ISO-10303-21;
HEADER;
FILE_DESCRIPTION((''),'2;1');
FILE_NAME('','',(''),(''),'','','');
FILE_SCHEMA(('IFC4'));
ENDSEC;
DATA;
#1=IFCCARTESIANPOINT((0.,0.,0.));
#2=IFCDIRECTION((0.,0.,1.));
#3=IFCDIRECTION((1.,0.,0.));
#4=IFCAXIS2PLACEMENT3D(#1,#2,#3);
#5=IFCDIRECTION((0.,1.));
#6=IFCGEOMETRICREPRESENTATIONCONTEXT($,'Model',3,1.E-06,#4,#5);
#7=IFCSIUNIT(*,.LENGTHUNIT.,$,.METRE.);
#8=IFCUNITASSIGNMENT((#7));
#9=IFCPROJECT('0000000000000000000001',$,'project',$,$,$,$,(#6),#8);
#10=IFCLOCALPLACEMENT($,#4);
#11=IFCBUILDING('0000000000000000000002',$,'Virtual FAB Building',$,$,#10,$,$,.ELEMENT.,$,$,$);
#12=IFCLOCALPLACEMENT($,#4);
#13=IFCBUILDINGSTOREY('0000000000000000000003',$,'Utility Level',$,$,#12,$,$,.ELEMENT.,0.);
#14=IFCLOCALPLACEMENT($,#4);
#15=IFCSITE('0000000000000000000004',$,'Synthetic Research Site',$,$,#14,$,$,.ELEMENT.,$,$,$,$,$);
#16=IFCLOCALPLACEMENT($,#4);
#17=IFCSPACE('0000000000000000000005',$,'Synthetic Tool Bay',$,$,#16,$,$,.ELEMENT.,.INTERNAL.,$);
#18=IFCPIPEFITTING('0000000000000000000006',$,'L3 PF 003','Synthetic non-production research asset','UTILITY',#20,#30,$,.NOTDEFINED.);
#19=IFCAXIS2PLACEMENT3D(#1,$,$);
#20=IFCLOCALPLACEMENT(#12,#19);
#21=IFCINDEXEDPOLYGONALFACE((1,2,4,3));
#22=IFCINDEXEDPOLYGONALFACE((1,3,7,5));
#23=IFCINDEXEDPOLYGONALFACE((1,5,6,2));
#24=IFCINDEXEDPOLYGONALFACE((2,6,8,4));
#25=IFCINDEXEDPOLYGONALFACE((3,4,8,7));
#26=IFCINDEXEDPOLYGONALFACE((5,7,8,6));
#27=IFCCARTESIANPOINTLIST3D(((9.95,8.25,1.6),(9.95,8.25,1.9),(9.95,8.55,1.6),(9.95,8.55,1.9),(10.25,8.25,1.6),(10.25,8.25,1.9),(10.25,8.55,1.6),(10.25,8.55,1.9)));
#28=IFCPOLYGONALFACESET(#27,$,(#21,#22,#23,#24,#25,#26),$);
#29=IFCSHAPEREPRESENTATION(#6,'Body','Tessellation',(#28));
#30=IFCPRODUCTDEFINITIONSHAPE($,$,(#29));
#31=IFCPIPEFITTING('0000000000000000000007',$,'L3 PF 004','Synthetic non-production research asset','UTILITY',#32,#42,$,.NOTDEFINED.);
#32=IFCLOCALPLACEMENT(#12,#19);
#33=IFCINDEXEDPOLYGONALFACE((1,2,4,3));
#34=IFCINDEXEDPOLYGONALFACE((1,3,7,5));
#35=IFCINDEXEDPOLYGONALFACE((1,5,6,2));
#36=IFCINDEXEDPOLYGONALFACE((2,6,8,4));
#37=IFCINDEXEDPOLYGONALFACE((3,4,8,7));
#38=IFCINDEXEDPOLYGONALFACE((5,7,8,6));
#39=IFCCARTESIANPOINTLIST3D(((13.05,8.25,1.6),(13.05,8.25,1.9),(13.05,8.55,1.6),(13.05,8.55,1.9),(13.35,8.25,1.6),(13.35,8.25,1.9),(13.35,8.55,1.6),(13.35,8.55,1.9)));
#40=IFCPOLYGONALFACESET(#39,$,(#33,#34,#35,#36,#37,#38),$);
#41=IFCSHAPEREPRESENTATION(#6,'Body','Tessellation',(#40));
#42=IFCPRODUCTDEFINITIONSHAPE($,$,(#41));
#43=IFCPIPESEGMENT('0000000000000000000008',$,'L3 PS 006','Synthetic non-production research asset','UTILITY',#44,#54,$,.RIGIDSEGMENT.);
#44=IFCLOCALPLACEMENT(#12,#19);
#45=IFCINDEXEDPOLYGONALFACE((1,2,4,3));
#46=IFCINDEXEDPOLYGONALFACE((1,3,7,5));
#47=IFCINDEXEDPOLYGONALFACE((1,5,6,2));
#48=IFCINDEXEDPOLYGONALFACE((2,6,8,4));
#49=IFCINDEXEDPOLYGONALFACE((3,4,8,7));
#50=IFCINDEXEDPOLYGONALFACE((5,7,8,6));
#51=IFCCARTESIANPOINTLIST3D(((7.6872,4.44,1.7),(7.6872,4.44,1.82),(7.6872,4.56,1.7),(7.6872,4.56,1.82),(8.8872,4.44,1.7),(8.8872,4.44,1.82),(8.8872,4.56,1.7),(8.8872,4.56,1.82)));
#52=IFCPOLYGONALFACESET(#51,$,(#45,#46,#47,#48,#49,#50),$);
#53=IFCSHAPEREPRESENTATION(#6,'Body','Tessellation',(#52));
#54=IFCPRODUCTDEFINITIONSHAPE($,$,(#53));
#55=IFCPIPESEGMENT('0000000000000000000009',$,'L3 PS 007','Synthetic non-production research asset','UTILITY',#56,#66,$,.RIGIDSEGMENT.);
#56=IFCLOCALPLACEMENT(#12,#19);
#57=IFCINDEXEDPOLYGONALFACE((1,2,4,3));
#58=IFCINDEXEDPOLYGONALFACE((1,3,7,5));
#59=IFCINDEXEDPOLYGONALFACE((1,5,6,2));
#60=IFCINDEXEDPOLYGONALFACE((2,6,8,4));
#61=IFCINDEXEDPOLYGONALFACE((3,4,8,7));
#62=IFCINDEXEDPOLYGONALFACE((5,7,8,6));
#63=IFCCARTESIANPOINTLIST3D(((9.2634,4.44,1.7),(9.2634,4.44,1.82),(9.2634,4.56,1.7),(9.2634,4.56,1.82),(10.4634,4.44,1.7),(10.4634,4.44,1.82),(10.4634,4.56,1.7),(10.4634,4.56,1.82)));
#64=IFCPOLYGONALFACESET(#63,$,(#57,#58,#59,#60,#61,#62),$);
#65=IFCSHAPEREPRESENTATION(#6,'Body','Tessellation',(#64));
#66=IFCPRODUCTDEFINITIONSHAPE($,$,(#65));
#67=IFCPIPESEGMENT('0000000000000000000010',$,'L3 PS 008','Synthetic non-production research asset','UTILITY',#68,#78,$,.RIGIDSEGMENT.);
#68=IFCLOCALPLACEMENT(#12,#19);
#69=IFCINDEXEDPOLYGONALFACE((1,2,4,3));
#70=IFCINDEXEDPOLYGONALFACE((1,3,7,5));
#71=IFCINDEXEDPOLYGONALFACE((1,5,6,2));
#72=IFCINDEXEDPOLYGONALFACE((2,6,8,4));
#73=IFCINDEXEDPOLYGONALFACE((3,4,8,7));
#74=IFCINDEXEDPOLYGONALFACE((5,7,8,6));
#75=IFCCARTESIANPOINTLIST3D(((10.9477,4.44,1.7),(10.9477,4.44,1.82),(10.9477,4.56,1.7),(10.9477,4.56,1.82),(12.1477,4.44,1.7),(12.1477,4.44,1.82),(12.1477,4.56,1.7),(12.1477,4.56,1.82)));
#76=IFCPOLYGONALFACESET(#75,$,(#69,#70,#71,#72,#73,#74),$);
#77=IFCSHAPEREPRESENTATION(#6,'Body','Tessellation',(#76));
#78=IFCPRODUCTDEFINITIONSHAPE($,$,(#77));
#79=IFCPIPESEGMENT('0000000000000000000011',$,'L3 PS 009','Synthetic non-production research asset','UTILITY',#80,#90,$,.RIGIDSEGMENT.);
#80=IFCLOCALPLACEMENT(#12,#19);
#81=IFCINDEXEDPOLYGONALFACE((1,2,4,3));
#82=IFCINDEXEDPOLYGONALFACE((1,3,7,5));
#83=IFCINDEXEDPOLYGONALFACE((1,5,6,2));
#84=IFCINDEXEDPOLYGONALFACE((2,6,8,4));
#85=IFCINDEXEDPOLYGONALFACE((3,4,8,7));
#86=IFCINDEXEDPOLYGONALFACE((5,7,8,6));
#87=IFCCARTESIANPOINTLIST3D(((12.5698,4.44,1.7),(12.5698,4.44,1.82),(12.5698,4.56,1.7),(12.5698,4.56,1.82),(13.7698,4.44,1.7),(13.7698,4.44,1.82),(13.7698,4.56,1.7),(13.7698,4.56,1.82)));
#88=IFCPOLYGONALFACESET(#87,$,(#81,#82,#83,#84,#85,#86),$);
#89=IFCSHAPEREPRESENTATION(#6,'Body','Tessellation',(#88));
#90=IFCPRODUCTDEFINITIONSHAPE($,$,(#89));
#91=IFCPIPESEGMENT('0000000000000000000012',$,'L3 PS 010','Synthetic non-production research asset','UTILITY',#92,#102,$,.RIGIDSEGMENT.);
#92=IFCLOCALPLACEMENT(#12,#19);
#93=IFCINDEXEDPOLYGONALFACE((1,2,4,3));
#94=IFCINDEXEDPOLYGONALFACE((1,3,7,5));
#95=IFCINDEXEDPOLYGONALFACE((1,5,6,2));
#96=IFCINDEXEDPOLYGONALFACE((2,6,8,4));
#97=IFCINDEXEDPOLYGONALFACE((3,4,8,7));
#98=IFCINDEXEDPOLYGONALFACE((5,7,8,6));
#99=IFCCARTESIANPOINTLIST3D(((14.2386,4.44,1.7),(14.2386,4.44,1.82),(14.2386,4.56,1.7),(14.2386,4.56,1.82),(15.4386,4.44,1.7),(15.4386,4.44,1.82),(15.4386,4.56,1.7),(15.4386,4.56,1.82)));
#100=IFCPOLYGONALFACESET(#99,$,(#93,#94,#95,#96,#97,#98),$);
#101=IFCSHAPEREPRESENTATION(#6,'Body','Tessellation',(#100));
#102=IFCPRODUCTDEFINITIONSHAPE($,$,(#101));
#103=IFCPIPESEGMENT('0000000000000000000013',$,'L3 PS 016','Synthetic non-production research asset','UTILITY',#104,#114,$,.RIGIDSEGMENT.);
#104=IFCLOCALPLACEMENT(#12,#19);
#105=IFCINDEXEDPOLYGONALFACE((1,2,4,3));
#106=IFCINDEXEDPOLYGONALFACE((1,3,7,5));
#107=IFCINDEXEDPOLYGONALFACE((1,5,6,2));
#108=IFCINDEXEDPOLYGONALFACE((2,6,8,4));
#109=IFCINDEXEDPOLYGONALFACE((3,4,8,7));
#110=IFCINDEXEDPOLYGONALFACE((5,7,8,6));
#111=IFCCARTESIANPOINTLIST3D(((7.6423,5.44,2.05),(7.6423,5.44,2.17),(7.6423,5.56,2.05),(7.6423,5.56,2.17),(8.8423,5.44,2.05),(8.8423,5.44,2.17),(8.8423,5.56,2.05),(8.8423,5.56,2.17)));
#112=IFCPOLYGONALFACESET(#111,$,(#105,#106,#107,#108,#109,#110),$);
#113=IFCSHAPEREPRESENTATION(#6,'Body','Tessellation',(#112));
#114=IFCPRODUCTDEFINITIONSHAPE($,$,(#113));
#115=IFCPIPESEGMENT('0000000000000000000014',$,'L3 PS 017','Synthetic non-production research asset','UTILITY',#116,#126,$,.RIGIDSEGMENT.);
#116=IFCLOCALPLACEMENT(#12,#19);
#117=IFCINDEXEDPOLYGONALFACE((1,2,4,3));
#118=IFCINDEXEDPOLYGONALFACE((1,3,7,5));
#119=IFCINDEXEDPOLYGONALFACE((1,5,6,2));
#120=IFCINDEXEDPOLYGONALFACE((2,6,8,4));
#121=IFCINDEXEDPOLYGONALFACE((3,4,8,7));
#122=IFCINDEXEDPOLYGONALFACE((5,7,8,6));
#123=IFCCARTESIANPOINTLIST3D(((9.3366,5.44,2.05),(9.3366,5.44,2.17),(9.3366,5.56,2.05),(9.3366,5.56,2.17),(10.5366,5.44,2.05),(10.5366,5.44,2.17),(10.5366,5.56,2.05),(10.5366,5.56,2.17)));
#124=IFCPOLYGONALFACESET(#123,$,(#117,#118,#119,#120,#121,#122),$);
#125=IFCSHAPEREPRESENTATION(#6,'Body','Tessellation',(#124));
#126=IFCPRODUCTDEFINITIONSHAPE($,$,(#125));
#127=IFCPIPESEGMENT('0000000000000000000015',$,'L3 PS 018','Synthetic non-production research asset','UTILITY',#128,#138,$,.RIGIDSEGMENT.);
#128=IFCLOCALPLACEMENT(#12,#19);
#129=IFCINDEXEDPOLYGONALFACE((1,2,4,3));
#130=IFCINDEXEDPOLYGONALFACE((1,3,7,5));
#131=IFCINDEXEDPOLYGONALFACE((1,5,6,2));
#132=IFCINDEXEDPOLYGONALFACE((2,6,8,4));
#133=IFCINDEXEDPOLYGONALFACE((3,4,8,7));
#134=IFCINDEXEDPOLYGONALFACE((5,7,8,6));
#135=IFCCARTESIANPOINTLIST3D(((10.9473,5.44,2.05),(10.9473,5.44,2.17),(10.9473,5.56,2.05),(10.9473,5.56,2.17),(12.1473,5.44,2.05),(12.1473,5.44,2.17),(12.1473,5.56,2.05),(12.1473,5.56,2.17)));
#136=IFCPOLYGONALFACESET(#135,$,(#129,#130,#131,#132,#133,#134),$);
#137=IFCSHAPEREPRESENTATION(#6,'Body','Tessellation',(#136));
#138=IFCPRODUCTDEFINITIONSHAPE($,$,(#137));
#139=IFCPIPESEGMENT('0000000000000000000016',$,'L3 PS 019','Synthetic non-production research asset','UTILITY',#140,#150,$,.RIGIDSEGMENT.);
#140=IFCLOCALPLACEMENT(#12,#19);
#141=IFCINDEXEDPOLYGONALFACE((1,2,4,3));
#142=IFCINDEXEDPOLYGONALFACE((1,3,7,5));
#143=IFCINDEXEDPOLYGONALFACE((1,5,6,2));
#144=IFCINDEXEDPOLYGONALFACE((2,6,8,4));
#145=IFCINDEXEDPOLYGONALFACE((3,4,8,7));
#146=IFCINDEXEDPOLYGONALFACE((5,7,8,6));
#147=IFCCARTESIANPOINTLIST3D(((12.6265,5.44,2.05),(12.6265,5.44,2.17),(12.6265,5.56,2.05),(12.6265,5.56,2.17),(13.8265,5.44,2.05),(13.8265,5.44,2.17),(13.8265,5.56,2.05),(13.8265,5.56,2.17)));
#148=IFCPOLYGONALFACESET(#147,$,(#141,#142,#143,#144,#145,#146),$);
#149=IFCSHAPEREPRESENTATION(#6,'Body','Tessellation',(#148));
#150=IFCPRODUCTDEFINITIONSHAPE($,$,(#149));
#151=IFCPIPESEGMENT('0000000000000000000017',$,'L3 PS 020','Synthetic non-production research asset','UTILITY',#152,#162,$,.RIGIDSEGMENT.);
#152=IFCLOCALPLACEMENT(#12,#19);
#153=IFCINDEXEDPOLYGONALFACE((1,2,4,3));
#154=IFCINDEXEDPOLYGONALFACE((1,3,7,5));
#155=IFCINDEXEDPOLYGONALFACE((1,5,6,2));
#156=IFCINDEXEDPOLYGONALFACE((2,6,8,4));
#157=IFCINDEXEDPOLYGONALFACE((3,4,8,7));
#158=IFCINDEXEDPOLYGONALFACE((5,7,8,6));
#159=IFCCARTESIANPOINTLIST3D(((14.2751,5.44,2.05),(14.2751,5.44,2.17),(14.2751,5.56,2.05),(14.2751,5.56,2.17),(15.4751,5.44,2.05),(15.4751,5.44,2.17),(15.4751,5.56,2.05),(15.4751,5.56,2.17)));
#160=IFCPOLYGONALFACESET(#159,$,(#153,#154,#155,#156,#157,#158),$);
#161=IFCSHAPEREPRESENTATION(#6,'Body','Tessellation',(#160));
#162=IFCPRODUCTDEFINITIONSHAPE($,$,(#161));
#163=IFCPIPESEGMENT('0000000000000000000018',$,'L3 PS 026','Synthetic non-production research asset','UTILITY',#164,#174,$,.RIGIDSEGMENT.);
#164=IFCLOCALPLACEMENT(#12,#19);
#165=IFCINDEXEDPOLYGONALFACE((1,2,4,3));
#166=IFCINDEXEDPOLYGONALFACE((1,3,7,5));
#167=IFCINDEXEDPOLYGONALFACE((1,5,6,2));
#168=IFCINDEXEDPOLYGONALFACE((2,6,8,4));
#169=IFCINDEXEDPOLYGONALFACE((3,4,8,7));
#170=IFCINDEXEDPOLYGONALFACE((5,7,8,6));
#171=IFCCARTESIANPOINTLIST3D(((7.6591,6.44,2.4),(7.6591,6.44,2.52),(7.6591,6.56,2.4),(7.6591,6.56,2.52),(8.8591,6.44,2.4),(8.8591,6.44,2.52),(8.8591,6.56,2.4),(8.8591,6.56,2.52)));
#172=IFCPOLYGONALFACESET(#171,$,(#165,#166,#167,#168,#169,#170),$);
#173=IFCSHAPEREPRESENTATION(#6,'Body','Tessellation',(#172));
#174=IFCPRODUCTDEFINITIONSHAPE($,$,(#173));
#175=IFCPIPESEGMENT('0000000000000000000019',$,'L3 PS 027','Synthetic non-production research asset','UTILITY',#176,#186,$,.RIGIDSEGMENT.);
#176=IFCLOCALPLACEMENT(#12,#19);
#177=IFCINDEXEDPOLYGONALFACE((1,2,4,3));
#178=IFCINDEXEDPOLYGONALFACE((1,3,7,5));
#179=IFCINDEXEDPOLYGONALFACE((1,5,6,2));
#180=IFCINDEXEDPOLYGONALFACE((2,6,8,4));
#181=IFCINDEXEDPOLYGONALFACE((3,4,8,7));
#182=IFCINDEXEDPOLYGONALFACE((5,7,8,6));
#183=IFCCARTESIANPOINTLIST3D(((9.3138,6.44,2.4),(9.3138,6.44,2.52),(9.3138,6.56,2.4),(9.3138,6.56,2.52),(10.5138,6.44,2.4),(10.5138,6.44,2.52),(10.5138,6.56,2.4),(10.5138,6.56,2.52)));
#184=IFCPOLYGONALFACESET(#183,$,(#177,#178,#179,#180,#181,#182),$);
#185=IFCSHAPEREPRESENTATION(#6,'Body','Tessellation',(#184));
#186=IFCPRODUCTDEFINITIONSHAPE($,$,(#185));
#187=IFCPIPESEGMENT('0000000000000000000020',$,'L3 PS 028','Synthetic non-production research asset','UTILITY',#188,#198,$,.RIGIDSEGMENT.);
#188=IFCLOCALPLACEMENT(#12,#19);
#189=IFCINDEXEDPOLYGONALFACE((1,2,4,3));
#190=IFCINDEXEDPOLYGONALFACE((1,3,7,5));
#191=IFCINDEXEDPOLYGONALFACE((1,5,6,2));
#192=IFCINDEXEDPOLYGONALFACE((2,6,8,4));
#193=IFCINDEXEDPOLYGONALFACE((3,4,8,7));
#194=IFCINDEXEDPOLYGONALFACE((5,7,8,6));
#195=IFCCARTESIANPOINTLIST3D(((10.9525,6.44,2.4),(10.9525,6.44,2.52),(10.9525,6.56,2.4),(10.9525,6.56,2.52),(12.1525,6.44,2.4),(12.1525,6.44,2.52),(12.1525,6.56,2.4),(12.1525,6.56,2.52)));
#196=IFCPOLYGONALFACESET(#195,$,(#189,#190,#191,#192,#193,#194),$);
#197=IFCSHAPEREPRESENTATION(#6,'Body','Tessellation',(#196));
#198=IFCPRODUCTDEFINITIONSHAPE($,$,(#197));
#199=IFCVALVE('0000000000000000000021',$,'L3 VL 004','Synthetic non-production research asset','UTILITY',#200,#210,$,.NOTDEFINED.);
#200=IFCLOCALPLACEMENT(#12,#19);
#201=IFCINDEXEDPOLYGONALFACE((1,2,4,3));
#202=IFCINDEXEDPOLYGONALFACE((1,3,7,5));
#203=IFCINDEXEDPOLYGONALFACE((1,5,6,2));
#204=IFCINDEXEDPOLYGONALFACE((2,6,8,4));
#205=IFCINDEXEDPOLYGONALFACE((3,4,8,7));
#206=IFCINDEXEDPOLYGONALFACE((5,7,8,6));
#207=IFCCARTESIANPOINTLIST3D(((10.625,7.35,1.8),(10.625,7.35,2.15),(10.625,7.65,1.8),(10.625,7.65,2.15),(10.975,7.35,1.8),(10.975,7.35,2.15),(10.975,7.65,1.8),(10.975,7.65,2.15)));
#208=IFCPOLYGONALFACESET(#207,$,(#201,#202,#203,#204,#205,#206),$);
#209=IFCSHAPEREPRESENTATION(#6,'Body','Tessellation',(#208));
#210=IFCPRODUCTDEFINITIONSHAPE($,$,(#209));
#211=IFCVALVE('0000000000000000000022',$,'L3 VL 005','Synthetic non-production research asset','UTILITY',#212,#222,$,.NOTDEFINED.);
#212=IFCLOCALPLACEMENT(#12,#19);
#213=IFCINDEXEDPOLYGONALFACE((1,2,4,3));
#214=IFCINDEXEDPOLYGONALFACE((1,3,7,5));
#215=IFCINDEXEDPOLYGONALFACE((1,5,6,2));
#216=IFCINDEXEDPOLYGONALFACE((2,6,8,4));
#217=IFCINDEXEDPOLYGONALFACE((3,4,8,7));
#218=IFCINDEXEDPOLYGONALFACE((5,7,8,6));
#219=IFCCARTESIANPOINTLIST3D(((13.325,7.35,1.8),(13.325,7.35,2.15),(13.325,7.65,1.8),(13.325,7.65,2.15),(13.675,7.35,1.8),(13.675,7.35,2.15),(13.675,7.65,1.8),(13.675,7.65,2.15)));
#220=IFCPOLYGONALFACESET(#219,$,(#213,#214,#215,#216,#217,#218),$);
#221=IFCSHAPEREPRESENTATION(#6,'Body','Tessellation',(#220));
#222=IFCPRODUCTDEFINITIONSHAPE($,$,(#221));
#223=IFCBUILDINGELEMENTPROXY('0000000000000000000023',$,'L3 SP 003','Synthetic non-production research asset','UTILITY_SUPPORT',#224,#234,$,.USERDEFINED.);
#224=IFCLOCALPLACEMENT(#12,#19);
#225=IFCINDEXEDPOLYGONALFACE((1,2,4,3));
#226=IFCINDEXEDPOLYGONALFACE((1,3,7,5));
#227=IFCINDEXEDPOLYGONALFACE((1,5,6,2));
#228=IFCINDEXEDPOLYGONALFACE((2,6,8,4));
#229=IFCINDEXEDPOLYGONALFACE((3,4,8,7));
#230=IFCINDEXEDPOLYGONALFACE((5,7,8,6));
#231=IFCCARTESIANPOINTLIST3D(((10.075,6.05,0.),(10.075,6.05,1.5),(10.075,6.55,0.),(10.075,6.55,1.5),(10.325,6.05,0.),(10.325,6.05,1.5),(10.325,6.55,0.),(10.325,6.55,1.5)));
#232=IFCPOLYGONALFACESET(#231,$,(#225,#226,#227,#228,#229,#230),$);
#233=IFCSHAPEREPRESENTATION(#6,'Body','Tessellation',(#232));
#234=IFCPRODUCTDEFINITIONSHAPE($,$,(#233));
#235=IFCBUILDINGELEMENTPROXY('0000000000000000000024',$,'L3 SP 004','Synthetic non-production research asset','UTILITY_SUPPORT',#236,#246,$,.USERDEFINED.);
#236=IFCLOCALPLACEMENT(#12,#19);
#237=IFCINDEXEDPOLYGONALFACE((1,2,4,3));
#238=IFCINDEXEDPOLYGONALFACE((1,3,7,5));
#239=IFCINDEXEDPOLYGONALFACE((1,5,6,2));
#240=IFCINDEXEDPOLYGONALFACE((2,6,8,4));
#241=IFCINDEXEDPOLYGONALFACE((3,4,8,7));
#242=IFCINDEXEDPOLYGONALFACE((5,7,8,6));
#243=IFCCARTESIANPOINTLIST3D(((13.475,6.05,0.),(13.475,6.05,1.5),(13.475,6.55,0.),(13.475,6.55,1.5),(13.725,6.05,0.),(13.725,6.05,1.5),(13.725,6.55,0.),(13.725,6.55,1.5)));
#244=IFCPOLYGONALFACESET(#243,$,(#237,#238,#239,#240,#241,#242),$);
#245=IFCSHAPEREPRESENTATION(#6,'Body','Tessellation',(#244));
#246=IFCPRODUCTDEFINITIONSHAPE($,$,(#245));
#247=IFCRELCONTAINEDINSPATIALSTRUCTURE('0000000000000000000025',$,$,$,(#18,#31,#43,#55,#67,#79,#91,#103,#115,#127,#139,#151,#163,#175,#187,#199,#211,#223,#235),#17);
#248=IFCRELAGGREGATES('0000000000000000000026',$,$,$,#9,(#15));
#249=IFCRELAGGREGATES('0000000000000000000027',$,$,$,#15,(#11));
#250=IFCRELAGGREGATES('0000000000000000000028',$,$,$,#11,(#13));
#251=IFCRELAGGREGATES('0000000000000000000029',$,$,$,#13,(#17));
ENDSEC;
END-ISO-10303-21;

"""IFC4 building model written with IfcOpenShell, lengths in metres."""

from ifc_helpers import new_model, si_unit, direction, frame, origin_with_axes, origin_2d_with_axis, place, context, project, spatial, rectangle, extrude, element, save


model = new_model("IFC4")

# Units and contexts
model_context = context("Model", 3, precision=1e-06, world=origin_with_axes(), true_north=direction((0.0, 1.0)))
ifc_project = project(units=[si_unit("LENGTHUNIT", "METRE")], contexts=[model_context])

# Site, building, storey, space
site_placement = place(None, origin_with_axes())
site = spatial("IfcSite", under=ifc_project, at=site_placement, Name="Synthetic Research Site", CompositionType="ELEMENT")
building_placement = place(None, origin_with_axes())
building = spatial("IfcBuilding", under=site, at=building_placement, Name="Virtual FAB Building", CompositionType="ELEMENT")
storey_placement = place(None, origin_with_axes())
storey = spatial("IfcBuildingStorey", under=building, at=storey_placement, Name="Utility Level", CompositionType="ELEMENT", Elevation=0.0)
space_placement = place(None, origin_with_axes())
space = spatial("IfcSpace", under=storey, at=space_placement, Name="Synthetic Tool Bay", CompositionType="ELEMENT", PredefinedType="INTERNAL")

# Pipe fittings
for number, where, z_axis, x_axis, name in (
    (1, (10.1, 8.4, 1.6), (0.0, 0.0, 1.0), (1.0, 0.0, 0.0), "L3 PF 003"),
    (2, (13.2, 8.4, 1.6), (0.0, 0.0, 1.0), (1.0, 0.0, 0.0), "L3 PF 004"),
):
    element("IfcPipeFitting", number, at=place(None, frame(where, z_axis=z_axis, x_axis=x_axis)), inside=space, Name=name, Description="Synthetic non-production research asset", ObjectType="UTILITY", PredefinedType="NOTDEFINED", context=model_context, shape_type="SweptSolid", body=[
        extrude(rectangle(XDim=0.3, YDim=0.3, at=origin_2d_with_axis()), origin_with_axes(), (0.0, 0.0, 1.0), 0.3),
    ])

# Pipe segments
for number, where, z_axis, x_axis, name in (
    (3, (8.2872, 4.5, 1.7), (0.0, 0.0, 1.0), (1.0, 0.0, 0.0), "L3 PS 006"),
    (4, (9.8634, 4.5, 1.7), (0.0, 0.0, 1.0), (1.0, 0.0, 0.0), "L3 PS 007"),
    (5, (11.5477, 4.5, 1.7), (0.0, 0.0, 1.0), (1.0, 0.0, 0.0), "L3 PS 008"),
    (6, (13.1698, 4.5, 1.7), (0.0, 0.0, 1.0), (1.0, 0.0, 0.0), "L3 PS 009"),
    (7, (14.8386, 4.5, 1.7), (0.0, 0.0, 1.0), (1.0, 0.0, 0.0), "L3 PS 010"),
    (8, (8.2423, 5.5, 2.05), (0.0, 0.0, 1.0), (1.0, 0.0, 0.0), "L3 PS 016"),
    (9, (9.9366, 5.5, 2.05), (0.0, 0.0, 1.0), (1.0, 0.0, 0.0), "L3 PS 017"),
    (10, (11.5473, 5.5, 2.05), (0.0, 0.0, 1.0), (1.0, 0.0, 0.0), "L3 PS 018"),
    (11, (13.2265, 5.5, 2.05), (0.0, 0.0, 1.0), (1.0, 0.0, 0.0), "L3 PS 019"),
    (12, (14.8751, 5.5, 2.05), (0.0, 0.0, 1.0), (1.0, 0.0, 0.0), "L3 PS 020"),
    (13, (8.2591, 6.5, 2.4), (0.0, 0.0, 1.0), (1.0, 0.0, 0.0), "L3 PS 026"),
    (14, (9.9138, 6.5, 2.4), (0.0, 0.0, 1.0), (1.0, 0.0, 0.0), "L3 PS 027"),
    (15, (11.5525, 6.5, 2.4), (0.0, 0.0, 1.0), (1.0, 0.0, 0.0), "L3 PS 028"),
):
    element("IfcPipeSegment", number, at=place(None, frame(where, z_axis=z_axis, x_axis=x_axis)), inside=space, Name=name, Description="Synthetic non-production research asset", ObjectType="UTILITY", PredefinedType="RIGIDSEGMENT", context=model_context, shape_type="SweptSolid", body=[
        extrude(rectangle(XDim=1.2, YDim=0.12, at=origin_2d_with_axis()), origin_with_axes(), (0.0, 0.0, 1.0), 0.12),
    ])

# Valves
for number, where, z_axis, x_axis, name in (
    (16, (10.8, 7.5, 1.8), (0.0, 0.0, 1.0), (1.0, 0.0, 0.0), "L3 VL 004"),
    (17, (13.5, 7.5, 1.8), (0.0, 0.0, 1.0), (1.0, 0.0, 0.0), "L3 VL 005"),
):
    element("IfcValve", number, at=place(None, frame(where, z_axis=z_axis, x_axis=x_axis)), inside=space, Name=name, Description="Synthetic non-production research asset", ObjectType="UTILITY", PredefinedType="NOTDEFINED", context=model_context, shape_type="SweptSolid", body=[
        extrude(rectangle(XDim=0.35, YDim=0.3, at=origin_2d_with_axis()), origin_with_axes(), (0.0, 0.0, 1.0), 0.35),
    ])

# Building element proxies
for number, where, z_axis, x_axis, name in (
    (18, (10.2, 6.3, 0.0), (0.0, 0.0, 1.0), (1.0, 0.0, 0.0), "L3 SP 003"),
    (19, (13.6, 6.3, 0.0), (0.0, 0.0, 1.0), (1.0, 0.0, 0.0), "L3 SP 004"),
):
    element("IfcBuildingElementProxy", number, at=place(None, frame(where, z_axis=z_axis, x_axis=x_axis)), inside=space, Name=name, Description="Synthetic non-production research asset", ObjectType="UTILITY_SUPPORT", PredefinedType="USERDEFINED", context=model_context, shape_type="SweptSolid", body=[
        extrude(rectangle(XDim=0.25, YDim=0.5, at=origin_2d_with_axis()), origin_with_axes(), (0.0, 0.0, 1.0), 1.5),
    ])

save(model, "model.ifc")
